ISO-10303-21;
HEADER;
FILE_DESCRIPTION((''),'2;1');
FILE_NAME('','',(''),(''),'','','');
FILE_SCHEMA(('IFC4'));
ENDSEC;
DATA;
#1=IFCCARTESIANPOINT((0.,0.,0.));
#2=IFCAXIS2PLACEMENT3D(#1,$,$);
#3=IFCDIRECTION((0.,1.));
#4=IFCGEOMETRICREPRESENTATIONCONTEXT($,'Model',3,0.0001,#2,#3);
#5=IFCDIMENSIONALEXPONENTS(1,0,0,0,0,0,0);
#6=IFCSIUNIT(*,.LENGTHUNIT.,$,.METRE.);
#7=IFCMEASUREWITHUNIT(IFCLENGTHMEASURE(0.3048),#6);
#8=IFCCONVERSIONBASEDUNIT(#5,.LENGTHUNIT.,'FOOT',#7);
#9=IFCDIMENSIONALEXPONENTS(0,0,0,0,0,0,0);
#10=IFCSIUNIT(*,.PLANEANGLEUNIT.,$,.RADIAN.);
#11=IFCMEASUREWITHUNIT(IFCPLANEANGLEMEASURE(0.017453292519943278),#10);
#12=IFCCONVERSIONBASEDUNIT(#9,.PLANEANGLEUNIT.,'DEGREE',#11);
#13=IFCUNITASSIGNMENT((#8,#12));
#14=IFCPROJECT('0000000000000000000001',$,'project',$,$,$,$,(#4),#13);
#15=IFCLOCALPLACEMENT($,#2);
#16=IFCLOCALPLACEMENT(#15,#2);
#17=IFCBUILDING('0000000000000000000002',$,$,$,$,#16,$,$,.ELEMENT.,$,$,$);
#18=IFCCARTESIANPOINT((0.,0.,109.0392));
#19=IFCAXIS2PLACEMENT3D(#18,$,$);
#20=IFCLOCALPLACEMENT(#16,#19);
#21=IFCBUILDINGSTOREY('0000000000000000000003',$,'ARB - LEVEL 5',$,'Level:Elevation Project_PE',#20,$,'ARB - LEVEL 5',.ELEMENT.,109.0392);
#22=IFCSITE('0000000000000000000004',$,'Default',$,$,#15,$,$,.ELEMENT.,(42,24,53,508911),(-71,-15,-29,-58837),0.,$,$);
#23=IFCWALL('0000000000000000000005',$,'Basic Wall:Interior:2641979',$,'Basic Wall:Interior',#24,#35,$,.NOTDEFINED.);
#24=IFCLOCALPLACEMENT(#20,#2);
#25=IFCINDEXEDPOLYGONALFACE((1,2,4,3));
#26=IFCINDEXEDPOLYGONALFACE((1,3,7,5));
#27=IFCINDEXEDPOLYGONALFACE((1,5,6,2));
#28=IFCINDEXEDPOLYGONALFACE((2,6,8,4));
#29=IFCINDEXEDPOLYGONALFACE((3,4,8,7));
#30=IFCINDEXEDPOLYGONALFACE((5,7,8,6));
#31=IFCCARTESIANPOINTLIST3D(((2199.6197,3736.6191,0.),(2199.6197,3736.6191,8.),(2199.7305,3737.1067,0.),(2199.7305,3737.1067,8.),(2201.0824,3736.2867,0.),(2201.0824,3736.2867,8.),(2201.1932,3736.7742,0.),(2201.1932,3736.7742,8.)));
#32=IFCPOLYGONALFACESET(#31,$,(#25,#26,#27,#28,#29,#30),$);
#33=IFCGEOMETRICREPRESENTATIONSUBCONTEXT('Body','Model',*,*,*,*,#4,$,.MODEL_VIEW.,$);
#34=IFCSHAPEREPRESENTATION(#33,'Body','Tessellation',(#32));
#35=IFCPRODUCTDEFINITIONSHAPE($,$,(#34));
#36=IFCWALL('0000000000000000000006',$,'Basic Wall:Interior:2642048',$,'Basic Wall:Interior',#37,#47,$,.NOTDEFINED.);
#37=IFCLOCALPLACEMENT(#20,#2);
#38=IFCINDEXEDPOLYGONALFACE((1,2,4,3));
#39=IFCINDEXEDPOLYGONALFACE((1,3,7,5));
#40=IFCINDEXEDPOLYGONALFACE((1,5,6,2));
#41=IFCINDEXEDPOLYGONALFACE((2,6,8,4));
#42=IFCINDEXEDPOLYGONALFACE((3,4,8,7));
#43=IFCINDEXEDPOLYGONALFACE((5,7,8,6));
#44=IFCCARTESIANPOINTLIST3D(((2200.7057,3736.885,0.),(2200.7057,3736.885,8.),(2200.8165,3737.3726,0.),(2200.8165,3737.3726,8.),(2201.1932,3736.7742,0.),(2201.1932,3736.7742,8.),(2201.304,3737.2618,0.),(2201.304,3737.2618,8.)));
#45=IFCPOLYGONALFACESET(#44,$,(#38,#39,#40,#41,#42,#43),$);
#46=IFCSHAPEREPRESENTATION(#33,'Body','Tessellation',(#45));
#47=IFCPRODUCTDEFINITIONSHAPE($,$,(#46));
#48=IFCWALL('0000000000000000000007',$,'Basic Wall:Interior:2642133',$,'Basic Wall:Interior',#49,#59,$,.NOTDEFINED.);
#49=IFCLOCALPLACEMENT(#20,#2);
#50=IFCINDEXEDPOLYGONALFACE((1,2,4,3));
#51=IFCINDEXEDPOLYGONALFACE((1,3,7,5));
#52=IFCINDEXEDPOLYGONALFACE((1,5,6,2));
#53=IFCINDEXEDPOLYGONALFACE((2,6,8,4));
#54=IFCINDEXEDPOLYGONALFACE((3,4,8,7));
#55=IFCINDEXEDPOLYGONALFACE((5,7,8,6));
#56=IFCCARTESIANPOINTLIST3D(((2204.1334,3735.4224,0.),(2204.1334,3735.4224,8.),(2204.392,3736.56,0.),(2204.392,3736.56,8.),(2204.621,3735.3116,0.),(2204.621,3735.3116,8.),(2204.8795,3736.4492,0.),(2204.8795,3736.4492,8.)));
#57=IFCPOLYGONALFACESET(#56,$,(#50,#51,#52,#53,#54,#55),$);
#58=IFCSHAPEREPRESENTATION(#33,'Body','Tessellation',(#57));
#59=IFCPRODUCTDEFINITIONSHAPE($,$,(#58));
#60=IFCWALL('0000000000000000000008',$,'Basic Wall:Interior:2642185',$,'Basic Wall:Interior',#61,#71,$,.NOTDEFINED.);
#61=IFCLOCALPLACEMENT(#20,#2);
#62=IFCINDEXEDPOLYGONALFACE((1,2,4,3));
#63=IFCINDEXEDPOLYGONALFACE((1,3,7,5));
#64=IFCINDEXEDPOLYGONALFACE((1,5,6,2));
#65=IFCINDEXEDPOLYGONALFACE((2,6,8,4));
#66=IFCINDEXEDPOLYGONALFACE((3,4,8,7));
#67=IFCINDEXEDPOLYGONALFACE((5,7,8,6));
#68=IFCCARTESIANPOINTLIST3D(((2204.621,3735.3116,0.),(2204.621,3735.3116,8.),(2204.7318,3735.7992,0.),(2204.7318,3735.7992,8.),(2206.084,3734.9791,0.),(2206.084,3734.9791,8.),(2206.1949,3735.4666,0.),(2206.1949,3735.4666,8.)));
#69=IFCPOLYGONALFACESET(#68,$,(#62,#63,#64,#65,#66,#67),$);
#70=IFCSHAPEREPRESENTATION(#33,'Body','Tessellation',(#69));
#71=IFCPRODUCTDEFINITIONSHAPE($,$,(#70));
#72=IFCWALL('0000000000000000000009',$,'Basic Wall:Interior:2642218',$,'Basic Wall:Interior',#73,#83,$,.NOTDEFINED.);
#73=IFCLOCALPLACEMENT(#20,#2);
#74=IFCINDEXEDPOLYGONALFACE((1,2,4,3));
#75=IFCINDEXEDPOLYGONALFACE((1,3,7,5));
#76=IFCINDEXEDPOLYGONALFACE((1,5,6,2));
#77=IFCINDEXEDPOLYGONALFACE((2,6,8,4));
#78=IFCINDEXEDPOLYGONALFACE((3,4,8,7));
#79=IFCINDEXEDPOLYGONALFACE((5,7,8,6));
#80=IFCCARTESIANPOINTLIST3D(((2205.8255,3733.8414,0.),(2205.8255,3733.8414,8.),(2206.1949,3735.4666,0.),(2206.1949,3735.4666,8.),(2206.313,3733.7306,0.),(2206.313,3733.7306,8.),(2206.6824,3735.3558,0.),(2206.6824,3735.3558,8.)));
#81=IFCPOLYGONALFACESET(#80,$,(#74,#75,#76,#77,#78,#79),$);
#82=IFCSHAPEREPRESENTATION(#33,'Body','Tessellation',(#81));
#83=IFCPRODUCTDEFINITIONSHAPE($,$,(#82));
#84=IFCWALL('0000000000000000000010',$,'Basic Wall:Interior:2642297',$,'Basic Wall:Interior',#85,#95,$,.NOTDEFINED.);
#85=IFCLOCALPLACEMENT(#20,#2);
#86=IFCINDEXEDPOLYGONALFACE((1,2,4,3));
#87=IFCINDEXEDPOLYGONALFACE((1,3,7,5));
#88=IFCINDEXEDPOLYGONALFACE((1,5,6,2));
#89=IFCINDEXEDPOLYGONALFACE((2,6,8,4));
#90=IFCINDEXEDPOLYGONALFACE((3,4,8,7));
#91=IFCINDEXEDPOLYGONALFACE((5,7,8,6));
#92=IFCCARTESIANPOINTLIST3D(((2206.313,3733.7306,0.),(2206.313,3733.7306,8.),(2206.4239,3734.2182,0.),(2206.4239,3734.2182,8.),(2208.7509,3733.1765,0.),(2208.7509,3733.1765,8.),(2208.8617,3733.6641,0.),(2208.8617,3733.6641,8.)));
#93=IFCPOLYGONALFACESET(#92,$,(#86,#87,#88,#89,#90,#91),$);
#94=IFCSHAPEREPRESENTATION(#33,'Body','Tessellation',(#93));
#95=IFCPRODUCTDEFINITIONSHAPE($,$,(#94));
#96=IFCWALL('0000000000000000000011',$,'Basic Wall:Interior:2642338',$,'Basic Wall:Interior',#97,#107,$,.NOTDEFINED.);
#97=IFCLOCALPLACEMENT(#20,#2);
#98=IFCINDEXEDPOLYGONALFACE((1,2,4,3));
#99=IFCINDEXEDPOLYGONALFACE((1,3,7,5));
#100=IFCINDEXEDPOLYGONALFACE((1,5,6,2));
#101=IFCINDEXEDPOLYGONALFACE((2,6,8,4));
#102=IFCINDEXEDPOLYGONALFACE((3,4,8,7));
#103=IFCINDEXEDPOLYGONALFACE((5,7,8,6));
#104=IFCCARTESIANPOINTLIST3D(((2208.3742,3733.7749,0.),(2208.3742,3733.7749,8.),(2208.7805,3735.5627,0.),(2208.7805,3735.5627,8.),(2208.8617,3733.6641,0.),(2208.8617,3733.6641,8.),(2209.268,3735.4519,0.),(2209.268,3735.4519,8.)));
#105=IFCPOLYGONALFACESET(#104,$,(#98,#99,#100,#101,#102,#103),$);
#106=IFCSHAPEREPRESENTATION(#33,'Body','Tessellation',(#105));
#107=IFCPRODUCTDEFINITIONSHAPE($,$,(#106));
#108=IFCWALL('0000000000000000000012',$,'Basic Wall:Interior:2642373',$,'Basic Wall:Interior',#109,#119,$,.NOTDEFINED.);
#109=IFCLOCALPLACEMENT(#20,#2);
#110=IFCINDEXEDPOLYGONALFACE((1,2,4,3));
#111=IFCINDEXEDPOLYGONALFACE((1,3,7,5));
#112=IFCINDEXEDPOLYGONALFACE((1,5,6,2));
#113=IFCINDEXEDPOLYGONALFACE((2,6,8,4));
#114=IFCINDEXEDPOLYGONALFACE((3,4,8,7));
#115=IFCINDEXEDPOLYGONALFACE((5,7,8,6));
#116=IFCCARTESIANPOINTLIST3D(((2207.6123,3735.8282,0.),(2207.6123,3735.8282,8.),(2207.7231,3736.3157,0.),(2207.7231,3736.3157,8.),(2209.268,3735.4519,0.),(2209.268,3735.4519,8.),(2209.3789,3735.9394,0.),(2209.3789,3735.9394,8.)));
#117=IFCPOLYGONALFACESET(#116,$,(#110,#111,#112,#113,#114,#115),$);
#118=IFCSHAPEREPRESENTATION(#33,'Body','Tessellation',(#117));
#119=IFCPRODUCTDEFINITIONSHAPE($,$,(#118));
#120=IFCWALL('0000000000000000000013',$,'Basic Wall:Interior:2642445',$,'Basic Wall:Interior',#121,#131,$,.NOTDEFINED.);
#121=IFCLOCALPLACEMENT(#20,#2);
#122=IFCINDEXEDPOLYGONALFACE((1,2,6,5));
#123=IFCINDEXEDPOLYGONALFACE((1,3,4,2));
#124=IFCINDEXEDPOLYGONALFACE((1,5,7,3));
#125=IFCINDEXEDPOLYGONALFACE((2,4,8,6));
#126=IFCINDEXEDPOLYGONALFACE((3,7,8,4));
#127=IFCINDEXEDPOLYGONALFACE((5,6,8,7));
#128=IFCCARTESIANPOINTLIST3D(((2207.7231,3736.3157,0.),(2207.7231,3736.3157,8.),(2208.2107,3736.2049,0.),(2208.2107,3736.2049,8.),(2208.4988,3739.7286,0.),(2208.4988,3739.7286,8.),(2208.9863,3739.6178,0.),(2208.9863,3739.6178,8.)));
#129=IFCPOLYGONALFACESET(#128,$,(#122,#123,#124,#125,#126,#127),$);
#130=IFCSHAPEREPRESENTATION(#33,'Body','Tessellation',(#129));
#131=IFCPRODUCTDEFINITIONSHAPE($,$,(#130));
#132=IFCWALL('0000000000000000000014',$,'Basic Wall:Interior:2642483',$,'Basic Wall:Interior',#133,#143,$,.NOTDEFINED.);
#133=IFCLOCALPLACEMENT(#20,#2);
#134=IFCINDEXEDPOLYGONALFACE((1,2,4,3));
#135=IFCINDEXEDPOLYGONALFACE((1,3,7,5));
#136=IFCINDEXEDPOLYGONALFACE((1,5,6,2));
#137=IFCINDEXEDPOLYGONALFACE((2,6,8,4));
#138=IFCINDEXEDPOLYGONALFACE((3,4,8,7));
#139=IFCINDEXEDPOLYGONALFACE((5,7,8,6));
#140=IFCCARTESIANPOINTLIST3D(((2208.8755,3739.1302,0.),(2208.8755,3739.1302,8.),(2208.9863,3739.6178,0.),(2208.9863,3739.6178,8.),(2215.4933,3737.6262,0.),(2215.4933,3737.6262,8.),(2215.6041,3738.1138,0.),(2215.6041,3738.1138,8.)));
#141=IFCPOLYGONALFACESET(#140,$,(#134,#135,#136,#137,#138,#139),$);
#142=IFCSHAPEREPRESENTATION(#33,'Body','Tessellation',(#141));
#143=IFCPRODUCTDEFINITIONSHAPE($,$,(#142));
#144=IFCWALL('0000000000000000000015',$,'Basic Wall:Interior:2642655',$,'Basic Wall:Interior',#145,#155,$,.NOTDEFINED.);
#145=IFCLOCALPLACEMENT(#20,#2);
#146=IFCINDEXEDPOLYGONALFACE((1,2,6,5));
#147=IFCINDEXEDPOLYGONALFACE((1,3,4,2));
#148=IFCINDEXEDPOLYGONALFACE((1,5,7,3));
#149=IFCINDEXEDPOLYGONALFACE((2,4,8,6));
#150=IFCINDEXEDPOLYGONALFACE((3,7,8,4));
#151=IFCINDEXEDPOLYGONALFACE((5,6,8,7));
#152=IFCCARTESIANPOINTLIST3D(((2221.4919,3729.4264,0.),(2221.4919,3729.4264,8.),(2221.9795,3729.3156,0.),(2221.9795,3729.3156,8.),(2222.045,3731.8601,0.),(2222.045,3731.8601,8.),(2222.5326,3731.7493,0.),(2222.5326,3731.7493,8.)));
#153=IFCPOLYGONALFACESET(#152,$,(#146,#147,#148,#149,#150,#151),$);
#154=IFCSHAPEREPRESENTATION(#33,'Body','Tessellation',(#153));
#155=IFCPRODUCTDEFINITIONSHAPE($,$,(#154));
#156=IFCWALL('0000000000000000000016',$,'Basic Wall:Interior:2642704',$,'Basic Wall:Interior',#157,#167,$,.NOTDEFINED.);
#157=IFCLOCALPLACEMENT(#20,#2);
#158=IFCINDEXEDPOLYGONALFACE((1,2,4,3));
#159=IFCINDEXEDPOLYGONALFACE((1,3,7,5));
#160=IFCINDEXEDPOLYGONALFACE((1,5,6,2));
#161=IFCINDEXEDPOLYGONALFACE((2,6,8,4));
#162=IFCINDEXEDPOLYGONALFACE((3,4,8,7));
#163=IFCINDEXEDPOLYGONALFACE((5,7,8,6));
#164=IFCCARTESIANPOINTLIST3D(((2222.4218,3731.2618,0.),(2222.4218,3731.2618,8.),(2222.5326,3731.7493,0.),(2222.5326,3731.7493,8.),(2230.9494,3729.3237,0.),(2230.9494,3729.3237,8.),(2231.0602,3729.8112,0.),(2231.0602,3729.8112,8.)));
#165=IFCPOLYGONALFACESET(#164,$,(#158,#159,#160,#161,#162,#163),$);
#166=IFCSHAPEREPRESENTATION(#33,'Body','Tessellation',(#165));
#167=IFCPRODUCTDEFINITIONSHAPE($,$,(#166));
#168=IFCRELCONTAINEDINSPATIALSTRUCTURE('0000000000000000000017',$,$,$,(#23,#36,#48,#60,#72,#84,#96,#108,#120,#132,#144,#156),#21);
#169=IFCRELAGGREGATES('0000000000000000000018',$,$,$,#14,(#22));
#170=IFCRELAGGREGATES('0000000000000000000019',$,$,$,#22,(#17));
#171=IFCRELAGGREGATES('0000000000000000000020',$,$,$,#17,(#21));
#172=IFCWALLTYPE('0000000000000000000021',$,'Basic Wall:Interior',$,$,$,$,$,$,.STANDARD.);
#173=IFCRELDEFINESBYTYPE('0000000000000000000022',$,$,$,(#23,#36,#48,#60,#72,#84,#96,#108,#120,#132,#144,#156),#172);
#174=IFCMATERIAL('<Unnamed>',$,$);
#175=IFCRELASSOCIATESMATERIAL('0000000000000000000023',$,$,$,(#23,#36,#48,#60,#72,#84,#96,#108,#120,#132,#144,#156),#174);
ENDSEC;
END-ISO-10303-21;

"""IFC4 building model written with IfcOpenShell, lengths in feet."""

from ifc_helpers import new_model, entity, si_unit, converted_unit, direction, frame, origin, place, context, subcontext, project, spatial, indexed_curve, outline, extrude, material, type_object, element, save


model = new_model("IFC4")

# Units and contexts
model_context = context("Model", 3, precision=0.0001, world=origin(), true_north=direction((0.0, 1.0)))
body_context = subcontext(model_context, "Body", "Model", "MODEL_VIEW")
ifc_project = project(units=[converted_unit("LENGTHUNIT", "FOOT", entity("IfcLengthMeasure", 0.3048), si_unit("LENGTHUNIT", "METRE"), dimensions=[1, 0, 0, 0, 0, 0, 0]), converted_unit("PLANEANGLEUNIT", "DEGREE", entity("IfcPlaneAngleMeasure", 0.017453292519943278), si_unit("PLANEANGLEUNIT", "RADIAN"), dimensions=[0, 0, 0, 0, 0, 0, 0])], contexts=[model_context])

# Site, building, storey
site_placement = place(None, origin())
site = spatial("IfcSite", under=ifc_project, at=site_placement, Name="Default", CompositionType="ELEMENT", RefLatitude=(42, 24, 53, 508911), RefLongitude=(-71, -15, -29, -58837), RefElevation=0.0)
building_placement = place(site_placement, origin())
building = spatial("IfcBuilding", under=site, at=building_placement, CompositionType="ELEMENT")
storey_placement = place(building_placement, frame((0.0, 0.0, 109.0392)))
storey = spatial("IfcBuildingStorey", under=building, at=storey_placement, Name="ARB - LEVEL 5", ObjectType="Level:Elevation Project_PE", LongName="ARB - LEVEL 5", CompositionType="ELEMENT", Elevation=109.0392)

# Walls
ifc_material_1 = material(Name="<Unnamed>")
wall_type = type_object("IfcWallType", Name="Basic Wall:Interior", PredefinedType="STANDARD")
wall_1_placement = place(storey_placement, frame((2199.6751, 3736.8629, 0.0), z_axis=(0.0, 0.0, 1.0), x_axis=(0.975133, -0.221622, 0.0)))
element("IfcWall", 1, at=wall_1_placement, inside=storey, type_object=wall_type, material=ifc_material_1, Name="Basic Wall:Interior:2641979", ObjectType="Basic Wall:Interior", PredefinedType="NOTDEFINED", context=body_context, shape_type="SweptSolid", body=[
    extrude(outline(indexed_curve([(1.5, 0.25), (0.0, 0.25), (0.0, -0.25), (1.5, -0.25), (1.5, 0.25)], self_intersect=False)), origin(), (0.0, 0.0, 1.0), 8.0),
])
wall_2_placement = place(storey_placement, frame((2200.9494, 3736.8296, 0.0), z_axis=(0.0, 0.0, 1.0), x_axis=(0.221622, 0.975133, 0.0)))
element("IfcWall", 2, at=wall_2_placement, inside=storey, type_object=wall_type, material=ifc_material_1, Name="Basic Wall:Interior:2642048", ObjectType="Basic Wall:Interior", PredefinedType="NOTDEFINED", context=body_context, shape_type="SweptSolid", body=[
    extrude(outline(indexed_curve([(0.5, 0.25), (0.0, 0.25), (0.0, -0.25), (0.5, -0.25), (0.5, 0.25)], self_intersect=False)), origin(), (0.0, 0.0, 1.0), 8.0),
])
wall_3_placement = place(storey_placement, frame((2204.6357, 3736.5046, 0.0), z_axis=(0.0, 0.0, 1.0), x_axis=(-0.221622, -0.975133, 0.0)))
element("IfcWall", 3, at=wall_3_placement, inside=storey, type_object=wall_type, material=ifc_material_1, Name="Basic Wall:Interior:2642133", ObjectType="Basic Wall:Interior", PredefinedType="NOTDEFINED", context=body_context, shape_type="SweptSolid", body=[
    extrude(outline(indexed_curve([(1.1666, 0.25), (0.0, 0.25), (0.0, -0.25), (1.1666, -0.25), (1.1666, 0.25)], self_intersect=False)), origin(), (0.0, 0.0, 1.0), 8.0),
])
wall_4_placement = place(storey_placement, frame((2204.6764, 3735.5554, 0.0), z_axis=(0.0, 0.0, 1.0), x_axis=(0.975133, -0.221622, 0.0)))
element("IfcWall", 4, at=wall_4_placement, inside=storey, type_object=wall_type, material=ifc_material_1, Name="Basic Wall:Interior:2642185", ObjectType="Basic Wall:Interior", PredefinedType="NOTDEFINED", context=body_context, shape_type="SweptSolid", body=[
    extrude(outline(indexed_curve([(1.5004, 0.25), (0.0, 0.25), (0.0, -0.25), (1.5004, -0.25), (1.5004, 0.25)], self_intersect=False)), origin(), (0.0, 0.0, 1.0), 8.0),
])
wall_5_placement = place(storey_placement, frame((2206.4386, 3735.4112, 0.0), z_axis=(0.0, 0.0, 1.0), x_axis=(-0.221622, -0.975133, 0.0)))
element("IfcWall", 5, at=wall_5_placement, inside=storey, type_object=wall_type, material=ifc_material_1, Name="Basic Wall:Interior:2642218", ObjectType="Basic Wall:Interior", PredefinedType="NOTDEFINED", context=body_context, shape_type="SweptSolid", body=[
    extrude(outline(indexed_curve([(1.6667, 0.25), (0.0, 0.25), (0.0, -0.25), (1.6667, -0.25), (1.6667, 0.25)], self_intersect=False)), origin(), (0.0, 0.0, 1.0), 8.0),
])
wall_6_placement = place(storey_placement, frame((2206.3685, 3733.9744, 0.0), z_axis=(0.0, 0.0, 1.0), x_axis=(0.975133, -0.221622, 0.0)))
element("IfcWall", 6, at=wall_6_placement, inside=storey, type_object=wall_type, material=ifc_material_1, Name="Basic Wall:Interior:2642297", ObjectType="Basic Wall:Interior", PredefinedType="NOTDEFINED", context=body_context, shape_type="SweptSolid", body=[
    extrude(outline(indexed_curve([(2.5, 0.25), (0.0, 0.25), (0.0, -0.25), (2.5, -0.25), (2.5, 0.25)], self_intersect=False)), origin(), (0.0, 0.0, 1.0), 8.0),
])
wall_7_placement = place(storey_placement, frame((2208.618, 3733.7195, 0.0), z_axis=(0.0, 0.0, 1.0), x_axis=(0.221622, 0.975133, 0.0)))
element("IfcWall", 7, at=wall_7_placement, inside=storey, type_object=wall_type, material=ifc_material_1, Name="Basic Wall:Interior:2642338", ObjectType="Basic Wall:Interior", PredefinedType="NOTDEFINED", context=body_context, shape_type="SweptSolid", body=[
    extrude(outline(indexed_curve([(1.8333, 0.25), (0.0, 0.25), (0.0, -0.25), (1.8333, -0.25), (1.8333, 0.25)], self_intersect=False)), origin(), (0.0, 0.0, 1.0), 8.0),
])
wall_8_placement = place(storey_placement, frame((2209.3235, 3735.6956, 0.0), z_axis=(0.0, 0.0, 1.0), x_axis=(-0.975133, 0.221622, 0.0)))
element("IfcWall", 8, at=wall_8_placement, inside=storey, type_object=wall_type, material=ifc_material_1, Name="Basic Wall:Interior:2642373", ObjectType="Basic Wall:Interior", PredefinedType="NOTDEFINED", context=body_context, shape_type="SweptSolid", body=[
    extrude(outline(indexed_curve([(1.698, 0.25), (0.0, 0.25), (0.0, -0.25), (1.698, -0.25), (1.698, 0.25)], self_intersect=False)), origin(), (0.0, 0.0, 1.0), 8.0),
])
wall_9_placement = place(storey_placement, frame((2207.9669, 3736.2603, 0.0), z_axis=(0.0, 0.0, 1.0), x_axis=(0.221622, 0.975133, 0.0)))
element("IfcWall", 9, at=wall_9_placement, inside=storey, type_object=wall_type, material=ifc_material_1, Name="Basic Wall:Interior:2642445", ObjectType="Basic Wall:Interior", PredefinedType="NOTDEFINED", context=body_context, shape_type="SweptSolid", body=[
    extrude(outline(indexed_curve([(3.4999, 0.25), (0.0, 0.25), (0.0, -0.25), (3.4999, -0.25), (3.4999, 0.25)], self_intersect=False)), origin(), (0.0, 0.0, 1.0), 8.0),
])
wall_10_placement = place(storey_placement, frame((2208.9309, 3739.374, 0.0), z_axis=(0.0, 0.0, 1.0), x_axis=(0.975133, -0.221622, 0.0)))
element("IfcWall", 10, at=wall_10_placement, inside=storey, type_object=wall_type, material=ifc_material_1, Name="Basic Wall:Interior:2642483", ObjectType="Basic Wall:Interior", PredefinedType="NOTDEFINED", context=body_context, shape_type="SweptSolid", body=[
    extrude(outline(indexed_curve([(6.7865, 0.25), (0.0, 0.25), (0.0, -0.25), (6.7865, -0.25), (6.7865, 0.25)], self_intersect=False)), origin(), (0.0, 0.0, 1.0), 8.0),
])
wall_11_placement = place(storey_placement, frame((2221.7357, 3729.371, 0.0), z_axis=(0.0, 0.0, 1.0), x_axis=(0.221622, 0.975133, 0.0)))
element("IfcWall", 11, at=wall_11_placement, inside=storey, type_object=wall_type, material=ifc_material_1, Name="Basic Wall:Interior:2642655", ObjectType="Basic Wall:Interior", PredefinedType="NOTDEFINED", context=body_context, shape_type="SweptSolid", body=[
    extrude(outline(indexed_curve([(2.4958, 0.25), (0.0, 0.25), (0.0, -0.25), (2.4958, -0.25), (2.4958, 0.25)], self_intersect=False)), origin(), (0.0, 0.0, 1.0), 8.0),
])
wall_12_placement = place(storey_placement, frame((2222.4772, 3731.5056, 0.0), z_axis=(0.0, 0.0, 1.0), x_axis=(0.975133, -0.221622, 0.0)))
element("IfcWall", 12, at=wall_12_placement, inside=storey, type_object=wall_type, material=ifc_material_1, Name="Basic Wall:Interior:2642704", ObjectType="Basic Wall:Interior", PredefinedType="NOTDEFINED", context=body_context, shape_type="SweptSolid", body=[
    extrude(outline(indexed_curve([(8.7451, 0.25), (0.0, 0.25), (0.0, -0.25), (8.7451, -0.25), (8.7451, 0.25)], self_intersect=False)), origin(), (0.0, 0.0, 1.0), 8.0),
])

save(model, "model.ifc")
